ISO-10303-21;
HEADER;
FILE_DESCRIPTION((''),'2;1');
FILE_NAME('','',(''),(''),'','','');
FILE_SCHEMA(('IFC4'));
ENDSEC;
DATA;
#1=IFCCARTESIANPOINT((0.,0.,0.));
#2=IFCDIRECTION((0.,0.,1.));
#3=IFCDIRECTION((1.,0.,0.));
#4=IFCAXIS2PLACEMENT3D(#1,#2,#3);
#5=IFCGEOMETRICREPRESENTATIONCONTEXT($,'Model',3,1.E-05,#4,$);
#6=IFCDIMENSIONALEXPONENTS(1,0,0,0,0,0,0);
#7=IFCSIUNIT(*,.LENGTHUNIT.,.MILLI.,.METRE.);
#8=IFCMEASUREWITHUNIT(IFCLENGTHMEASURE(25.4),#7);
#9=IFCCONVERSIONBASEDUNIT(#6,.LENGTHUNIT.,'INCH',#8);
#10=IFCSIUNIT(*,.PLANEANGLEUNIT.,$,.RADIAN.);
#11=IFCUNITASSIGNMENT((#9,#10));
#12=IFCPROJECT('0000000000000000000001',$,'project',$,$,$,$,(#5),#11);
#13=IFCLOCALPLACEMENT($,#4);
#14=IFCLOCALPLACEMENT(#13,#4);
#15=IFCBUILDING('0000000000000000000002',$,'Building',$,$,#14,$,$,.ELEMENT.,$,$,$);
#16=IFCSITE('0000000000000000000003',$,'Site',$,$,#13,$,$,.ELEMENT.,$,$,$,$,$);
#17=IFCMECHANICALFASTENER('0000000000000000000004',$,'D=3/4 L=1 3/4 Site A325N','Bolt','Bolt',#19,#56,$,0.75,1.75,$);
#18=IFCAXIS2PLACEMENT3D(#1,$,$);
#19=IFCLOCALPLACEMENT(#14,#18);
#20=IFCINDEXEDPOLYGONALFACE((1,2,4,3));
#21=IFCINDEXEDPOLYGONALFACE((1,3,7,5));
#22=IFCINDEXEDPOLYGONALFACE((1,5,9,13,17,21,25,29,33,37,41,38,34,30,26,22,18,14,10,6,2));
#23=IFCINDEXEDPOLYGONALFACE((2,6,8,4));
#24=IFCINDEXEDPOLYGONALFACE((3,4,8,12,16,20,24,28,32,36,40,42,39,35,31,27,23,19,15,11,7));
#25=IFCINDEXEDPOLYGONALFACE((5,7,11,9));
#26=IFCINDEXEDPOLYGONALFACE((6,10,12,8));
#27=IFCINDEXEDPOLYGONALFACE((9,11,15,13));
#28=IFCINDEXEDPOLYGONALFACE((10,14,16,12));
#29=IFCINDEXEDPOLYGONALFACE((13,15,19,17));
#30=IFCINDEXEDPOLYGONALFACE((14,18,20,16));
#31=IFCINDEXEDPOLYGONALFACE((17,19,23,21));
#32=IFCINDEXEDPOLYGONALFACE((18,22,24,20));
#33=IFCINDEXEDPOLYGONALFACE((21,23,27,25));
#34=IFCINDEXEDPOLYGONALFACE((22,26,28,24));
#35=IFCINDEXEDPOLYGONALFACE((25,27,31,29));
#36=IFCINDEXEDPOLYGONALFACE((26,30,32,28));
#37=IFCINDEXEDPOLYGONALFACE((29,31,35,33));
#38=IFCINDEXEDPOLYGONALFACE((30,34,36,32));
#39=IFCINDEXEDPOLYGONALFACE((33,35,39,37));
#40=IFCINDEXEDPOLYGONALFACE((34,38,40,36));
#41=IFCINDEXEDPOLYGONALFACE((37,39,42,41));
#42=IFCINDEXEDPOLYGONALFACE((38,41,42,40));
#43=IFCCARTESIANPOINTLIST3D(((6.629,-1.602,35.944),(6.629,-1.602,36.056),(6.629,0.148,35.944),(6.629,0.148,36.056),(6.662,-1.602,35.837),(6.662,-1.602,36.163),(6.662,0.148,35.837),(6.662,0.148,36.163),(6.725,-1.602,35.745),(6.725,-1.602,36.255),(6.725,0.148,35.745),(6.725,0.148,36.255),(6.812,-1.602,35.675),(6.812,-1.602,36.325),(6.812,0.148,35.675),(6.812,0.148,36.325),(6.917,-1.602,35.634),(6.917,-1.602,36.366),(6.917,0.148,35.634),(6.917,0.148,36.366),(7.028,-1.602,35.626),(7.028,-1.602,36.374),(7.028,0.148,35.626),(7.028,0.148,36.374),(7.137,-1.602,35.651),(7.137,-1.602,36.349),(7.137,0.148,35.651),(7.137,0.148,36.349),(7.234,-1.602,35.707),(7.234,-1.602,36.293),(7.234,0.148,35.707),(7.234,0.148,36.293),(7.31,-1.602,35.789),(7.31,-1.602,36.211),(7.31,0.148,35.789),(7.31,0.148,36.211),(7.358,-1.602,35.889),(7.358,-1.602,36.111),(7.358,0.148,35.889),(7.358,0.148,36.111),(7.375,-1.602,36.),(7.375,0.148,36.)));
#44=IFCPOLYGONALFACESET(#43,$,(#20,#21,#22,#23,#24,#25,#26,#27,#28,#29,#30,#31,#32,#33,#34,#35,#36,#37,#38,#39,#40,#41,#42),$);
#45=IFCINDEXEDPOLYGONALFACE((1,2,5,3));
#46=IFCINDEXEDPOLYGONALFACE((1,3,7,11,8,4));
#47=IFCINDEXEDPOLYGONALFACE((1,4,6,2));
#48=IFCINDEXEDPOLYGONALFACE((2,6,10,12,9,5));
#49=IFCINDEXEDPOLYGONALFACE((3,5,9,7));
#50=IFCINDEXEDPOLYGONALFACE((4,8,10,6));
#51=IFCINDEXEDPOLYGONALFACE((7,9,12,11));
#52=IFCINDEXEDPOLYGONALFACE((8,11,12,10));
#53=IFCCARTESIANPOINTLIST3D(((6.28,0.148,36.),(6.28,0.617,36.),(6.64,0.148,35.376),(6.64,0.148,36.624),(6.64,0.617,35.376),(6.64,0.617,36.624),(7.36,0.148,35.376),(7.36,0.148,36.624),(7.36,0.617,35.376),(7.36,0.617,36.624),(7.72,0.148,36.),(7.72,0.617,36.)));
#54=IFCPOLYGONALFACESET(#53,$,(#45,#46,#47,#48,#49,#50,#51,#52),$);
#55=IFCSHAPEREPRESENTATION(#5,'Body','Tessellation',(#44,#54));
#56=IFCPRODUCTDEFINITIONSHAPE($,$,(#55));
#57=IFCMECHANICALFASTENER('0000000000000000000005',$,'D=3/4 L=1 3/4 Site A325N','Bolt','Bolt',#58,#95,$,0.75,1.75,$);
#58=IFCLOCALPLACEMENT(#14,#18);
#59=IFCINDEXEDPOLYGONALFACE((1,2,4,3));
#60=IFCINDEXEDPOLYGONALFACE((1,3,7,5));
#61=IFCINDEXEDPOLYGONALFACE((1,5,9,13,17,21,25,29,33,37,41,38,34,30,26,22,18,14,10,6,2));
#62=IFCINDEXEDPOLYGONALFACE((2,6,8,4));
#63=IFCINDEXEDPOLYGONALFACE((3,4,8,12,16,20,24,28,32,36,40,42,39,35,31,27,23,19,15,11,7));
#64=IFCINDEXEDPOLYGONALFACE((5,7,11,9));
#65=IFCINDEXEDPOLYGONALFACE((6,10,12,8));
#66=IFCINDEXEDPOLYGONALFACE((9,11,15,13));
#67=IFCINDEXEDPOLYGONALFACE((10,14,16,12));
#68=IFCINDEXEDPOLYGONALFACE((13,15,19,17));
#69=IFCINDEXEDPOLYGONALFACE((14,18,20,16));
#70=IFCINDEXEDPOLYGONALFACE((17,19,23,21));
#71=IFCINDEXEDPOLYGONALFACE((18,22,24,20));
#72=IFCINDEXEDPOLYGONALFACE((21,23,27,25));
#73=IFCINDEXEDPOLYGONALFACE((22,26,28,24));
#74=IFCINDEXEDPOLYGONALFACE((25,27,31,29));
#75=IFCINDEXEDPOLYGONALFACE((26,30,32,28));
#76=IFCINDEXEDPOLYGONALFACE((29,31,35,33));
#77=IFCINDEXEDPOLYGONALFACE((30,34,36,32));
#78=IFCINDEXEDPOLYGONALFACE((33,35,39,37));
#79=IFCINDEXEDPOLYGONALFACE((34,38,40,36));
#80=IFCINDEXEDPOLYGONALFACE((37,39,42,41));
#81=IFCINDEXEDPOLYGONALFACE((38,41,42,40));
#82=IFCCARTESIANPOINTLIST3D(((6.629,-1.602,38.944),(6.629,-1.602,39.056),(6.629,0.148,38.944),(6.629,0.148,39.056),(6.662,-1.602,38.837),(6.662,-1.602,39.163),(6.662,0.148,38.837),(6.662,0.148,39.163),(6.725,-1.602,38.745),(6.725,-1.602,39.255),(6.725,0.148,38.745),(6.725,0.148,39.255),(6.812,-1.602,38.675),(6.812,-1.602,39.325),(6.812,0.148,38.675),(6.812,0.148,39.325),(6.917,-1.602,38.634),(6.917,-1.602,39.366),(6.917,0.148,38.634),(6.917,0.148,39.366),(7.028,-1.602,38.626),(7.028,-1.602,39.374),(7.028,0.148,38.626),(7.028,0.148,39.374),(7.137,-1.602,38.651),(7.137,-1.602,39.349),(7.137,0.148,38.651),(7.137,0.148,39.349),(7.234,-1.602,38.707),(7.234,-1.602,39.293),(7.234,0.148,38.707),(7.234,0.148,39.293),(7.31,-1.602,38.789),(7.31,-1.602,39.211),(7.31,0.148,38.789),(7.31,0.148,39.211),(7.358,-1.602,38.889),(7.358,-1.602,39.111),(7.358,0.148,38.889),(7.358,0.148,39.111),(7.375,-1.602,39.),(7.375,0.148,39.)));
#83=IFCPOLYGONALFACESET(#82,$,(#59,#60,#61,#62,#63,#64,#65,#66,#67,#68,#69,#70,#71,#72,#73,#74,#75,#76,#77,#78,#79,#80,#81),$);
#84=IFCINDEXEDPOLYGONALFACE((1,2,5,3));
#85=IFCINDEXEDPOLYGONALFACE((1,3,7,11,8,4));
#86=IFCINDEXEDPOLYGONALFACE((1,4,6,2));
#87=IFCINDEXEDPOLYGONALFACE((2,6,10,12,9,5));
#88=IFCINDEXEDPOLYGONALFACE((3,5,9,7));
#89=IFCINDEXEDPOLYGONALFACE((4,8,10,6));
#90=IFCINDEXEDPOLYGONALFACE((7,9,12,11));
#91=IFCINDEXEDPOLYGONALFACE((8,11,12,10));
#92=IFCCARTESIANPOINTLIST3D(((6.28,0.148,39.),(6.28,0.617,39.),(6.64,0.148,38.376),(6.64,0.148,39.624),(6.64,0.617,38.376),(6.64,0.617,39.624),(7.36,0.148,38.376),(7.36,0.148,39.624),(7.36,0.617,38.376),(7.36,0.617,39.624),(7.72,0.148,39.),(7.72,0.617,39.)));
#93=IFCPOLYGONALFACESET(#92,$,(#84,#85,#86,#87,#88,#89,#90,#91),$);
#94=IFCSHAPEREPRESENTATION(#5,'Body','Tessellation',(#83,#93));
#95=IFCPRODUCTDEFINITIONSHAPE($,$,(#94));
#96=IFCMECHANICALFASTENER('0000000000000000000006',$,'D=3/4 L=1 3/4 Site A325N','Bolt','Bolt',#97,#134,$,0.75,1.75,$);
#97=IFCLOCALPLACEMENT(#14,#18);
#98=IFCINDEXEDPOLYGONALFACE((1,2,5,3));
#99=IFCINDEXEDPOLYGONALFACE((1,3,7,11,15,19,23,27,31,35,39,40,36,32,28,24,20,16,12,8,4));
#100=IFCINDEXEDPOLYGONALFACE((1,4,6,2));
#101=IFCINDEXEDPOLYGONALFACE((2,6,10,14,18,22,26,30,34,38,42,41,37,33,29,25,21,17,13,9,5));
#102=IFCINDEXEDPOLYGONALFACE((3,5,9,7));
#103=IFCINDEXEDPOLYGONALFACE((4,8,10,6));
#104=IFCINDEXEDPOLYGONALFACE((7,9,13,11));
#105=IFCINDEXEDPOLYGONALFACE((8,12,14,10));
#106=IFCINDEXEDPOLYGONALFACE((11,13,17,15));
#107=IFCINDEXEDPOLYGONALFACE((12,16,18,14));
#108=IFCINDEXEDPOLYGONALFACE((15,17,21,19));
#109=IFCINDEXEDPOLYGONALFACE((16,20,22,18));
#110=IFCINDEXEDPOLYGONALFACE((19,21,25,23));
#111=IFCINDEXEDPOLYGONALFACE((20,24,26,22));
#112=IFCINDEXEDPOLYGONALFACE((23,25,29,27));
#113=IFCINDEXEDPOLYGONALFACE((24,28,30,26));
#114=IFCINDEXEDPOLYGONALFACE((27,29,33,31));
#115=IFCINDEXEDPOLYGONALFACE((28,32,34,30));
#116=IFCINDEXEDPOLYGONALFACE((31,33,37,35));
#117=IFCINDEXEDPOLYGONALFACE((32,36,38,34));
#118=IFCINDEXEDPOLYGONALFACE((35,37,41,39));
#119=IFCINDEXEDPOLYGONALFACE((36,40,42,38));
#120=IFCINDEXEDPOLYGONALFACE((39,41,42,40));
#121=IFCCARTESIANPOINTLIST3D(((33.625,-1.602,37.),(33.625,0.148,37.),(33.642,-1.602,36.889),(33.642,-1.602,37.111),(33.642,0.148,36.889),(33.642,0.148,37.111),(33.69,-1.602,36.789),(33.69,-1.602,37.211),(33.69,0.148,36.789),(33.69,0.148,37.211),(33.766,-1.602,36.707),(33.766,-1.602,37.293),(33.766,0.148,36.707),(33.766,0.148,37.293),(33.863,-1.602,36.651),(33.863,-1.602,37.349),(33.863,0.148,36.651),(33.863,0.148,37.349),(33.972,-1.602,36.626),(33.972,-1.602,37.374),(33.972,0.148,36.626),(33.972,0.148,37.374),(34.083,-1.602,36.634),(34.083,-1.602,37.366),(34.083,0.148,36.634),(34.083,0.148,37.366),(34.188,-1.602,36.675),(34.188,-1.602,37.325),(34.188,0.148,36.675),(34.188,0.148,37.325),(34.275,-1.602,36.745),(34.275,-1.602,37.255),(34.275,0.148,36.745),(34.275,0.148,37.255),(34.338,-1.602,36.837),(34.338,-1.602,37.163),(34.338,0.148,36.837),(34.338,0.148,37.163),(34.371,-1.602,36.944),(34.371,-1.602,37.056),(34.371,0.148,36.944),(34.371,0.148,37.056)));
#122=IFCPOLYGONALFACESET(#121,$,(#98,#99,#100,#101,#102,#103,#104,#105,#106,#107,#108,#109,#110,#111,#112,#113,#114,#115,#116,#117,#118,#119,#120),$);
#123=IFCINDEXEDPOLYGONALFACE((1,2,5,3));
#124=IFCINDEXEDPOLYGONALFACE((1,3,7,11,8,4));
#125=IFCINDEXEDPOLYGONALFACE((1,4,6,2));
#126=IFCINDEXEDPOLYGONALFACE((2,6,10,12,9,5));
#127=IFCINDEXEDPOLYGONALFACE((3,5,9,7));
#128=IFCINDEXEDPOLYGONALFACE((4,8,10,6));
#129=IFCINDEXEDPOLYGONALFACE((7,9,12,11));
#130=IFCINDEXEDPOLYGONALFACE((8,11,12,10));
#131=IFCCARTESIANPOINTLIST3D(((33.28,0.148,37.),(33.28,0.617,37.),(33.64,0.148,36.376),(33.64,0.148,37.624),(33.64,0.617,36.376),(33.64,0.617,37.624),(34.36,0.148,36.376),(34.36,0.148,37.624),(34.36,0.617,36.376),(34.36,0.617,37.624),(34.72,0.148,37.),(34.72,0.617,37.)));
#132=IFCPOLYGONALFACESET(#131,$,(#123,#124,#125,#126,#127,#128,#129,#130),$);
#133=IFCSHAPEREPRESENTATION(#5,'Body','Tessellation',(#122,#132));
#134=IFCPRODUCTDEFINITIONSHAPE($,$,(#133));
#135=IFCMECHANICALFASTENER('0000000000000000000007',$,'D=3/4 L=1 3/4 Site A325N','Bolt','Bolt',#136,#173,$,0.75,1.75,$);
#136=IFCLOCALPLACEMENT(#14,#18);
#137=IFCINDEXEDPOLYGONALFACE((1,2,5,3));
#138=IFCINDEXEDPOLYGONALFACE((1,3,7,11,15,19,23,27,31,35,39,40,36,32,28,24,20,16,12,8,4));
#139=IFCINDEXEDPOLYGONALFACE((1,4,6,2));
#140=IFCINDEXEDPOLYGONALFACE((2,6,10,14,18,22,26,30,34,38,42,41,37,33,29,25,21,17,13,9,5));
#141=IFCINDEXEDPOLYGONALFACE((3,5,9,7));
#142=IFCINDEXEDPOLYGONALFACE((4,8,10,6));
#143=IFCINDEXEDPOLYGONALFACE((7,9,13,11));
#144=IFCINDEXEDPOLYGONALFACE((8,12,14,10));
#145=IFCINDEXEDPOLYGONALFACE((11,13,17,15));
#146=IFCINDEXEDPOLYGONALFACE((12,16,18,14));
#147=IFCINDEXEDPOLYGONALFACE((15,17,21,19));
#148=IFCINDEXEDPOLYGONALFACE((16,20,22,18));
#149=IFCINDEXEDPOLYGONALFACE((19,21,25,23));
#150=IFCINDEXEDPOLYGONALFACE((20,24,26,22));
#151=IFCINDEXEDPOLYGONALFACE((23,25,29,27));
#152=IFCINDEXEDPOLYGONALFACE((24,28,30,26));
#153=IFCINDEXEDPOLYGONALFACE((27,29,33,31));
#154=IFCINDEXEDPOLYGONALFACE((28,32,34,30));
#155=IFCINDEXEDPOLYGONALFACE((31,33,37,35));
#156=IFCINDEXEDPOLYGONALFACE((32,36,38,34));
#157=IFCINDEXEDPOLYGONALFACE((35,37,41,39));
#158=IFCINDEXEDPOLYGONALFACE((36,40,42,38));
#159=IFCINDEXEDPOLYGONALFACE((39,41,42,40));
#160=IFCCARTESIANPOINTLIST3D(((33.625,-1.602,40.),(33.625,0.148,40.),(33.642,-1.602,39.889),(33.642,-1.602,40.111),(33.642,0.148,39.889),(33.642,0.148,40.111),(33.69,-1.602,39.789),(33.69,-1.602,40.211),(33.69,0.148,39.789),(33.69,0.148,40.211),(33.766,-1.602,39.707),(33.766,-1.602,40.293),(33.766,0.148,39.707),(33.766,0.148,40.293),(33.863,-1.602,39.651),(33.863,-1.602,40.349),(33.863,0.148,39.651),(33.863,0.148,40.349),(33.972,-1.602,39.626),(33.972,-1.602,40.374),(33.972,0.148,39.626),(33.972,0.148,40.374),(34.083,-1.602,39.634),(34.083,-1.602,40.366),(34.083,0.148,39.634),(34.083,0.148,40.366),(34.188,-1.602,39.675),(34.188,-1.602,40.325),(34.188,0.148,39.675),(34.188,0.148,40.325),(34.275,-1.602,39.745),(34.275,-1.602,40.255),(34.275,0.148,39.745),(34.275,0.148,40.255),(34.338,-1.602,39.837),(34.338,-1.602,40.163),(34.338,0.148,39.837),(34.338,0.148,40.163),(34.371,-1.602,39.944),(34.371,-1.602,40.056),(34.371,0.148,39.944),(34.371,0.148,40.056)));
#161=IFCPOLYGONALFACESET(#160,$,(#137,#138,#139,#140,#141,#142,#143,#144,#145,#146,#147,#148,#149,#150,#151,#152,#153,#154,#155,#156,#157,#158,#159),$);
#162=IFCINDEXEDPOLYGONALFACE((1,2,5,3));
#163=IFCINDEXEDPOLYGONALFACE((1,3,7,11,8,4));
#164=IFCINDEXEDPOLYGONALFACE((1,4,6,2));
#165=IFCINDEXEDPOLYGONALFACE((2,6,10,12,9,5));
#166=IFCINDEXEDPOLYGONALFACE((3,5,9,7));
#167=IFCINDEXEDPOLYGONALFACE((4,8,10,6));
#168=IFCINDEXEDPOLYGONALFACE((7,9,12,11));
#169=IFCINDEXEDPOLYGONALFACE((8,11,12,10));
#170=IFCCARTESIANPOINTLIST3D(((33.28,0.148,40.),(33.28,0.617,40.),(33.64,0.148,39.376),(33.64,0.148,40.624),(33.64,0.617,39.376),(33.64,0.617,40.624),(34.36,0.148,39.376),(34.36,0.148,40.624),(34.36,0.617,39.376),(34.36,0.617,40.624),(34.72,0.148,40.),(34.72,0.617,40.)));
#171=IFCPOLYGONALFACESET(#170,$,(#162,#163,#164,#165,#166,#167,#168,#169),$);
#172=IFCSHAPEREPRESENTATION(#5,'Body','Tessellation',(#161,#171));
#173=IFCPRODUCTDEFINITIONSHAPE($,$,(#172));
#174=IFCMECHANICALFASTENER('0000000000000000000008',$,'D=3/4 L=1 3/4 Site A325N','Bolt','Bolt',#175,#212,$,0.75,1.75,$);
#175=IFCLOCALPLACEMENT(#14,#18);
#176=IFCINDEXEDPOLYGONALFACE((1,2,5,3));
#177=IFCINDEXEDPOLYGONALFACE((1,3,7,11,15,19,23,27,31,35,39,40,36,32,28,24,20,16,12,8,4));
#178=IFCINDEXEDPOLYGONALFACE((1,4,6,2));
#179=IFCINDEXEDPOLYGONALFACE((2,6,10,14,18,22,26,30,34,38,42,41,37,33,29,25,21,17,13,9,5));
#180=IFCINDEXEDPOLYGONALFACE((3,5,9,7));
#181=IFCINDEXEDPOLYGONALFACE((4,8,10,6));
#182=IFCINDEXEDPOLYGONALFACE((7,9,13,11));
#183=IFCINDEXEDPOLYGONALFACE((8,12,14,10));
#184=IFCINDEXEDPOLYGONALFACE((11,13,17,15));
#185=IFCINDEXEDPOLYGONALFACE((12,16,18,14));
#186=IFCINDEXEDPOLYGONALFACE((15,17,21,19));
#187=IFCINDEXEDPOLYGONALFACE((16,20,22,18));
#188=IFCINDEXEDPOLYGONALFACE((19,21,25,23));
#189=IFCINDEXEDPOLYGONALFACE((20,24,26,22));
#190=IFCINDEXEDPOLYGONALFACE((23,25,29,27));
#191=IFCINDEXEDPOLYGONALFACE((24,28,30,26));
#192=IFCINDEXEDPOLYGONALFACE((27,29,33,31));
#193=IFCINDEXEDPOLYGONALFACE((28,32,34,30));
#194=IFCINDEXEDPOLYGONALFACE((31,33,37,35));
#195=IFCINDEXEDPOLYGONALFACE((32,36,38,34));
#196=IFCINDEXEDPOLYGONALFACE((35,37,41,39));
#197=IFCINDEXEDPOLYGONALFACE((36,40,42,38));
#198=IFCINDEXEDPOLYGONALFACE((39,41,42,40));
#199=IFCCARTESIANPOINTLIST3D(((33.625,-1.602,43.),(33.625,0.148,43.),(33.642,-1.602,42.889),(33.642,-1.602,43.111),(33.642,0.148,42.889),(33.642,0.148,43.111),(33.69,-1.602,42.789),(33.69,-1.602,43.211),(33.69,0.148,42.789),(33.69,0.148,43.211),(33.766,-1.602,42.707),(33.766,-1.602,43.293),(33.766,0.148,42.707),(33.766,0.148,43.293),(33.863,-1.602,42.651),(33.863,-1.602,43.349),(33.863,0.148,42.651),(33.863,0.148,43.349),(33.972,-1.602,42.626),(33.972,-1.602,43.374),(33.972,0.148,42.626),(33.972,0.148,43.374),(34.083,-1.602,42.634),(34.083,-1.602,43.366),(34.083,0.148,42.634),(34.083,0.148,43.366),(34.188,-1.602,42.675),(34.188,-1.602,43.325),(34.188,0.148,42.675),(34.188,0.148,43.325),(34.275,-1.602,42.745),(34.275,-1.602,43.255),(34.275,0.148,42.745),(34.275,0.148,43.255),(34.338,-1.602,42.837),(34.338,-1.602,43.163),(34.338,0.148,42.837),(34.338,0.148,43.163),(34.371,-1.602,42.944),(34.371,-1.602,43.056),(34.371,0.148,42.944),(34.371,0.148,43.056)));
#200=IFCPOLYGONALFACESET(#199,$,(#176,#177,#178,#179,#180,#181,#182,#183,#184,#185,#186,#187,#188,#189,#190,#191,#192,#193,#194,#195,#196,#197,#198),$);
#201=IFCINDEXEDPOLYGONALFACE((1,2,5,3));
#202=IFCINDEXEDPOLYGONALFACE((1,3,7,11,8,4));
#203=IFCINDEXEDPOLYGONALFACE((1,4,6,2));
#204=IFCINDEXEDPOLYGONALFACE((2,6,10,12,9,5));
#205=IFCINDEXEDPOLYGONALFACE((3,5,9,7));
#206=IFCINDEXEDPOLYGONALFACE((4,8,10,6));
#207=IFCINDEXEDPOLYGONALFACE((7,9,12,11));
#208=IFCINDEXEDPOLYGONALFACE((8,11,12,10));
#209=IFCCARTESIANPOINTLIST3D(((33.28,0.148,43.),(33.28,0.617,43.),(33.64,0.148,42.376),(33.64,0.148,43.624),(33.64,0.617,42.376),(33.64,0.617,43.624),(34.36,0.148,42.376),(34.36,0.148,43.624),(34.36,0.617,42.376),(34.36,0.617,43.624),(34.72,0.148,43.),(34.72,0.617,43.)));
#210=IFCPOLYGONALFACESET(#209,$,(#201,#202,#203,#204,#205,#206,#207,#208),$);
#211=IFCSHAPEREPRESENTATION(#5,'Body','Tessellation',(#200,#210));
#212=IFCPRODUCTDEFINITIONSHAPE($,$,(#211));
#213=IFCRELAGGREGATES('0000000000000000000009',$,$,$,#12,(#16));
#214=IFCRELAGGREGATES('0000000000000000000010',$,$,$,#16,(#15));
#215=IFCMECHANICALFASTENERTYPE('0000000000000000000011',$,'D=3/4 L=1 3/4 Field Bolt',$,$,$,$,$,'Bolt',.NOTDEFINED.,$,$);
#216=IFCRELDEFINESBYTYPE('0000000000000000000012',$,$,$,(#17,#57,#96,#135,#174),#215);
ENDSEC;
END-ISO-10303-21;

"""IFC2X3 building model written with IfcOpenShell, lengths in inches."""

from ifc_helpers import new_model, entity, si_unit, converted_unit, frame, origin_with_axes, origin_2d_with_axis, place, context, project, spatial, polyline, circle, outline, extrude, source, transform, mapped, type_object, type_shapes, element, save


model = new_model("IFC2X3")

# Units and contexts
model_context = context("Model", 3, precision=1e-05, world=origin_with_axes())
ifc_project = project(units=[converted_unit("LENGTHUNIT", "INCH", entity("IfcLengthMeasure", 25.4), si_unit("LENGTHUNIT", "METRE", prefix="MILLI"), dimensions=[1, 0, 0, 0, 0, 0, 0]), si_unit("PLANEANGLEUNIT", "RADIAN")], contexts=[model_context])

# Site, building
site_placement = place(None, origin_with_axes())
site = spatial("IfcSite", under=ifc_project, at=site_placement, Name="Site", CompositionType="ELEMENT")
building_placement = place(site_placement, origin_with_axes())
building = spatial("IfcBuilding", under=site, at=building_placement, Name="Building", CompositionType="ELEMENT")

# Mechanical fasteners
mechanical_fastener_type_1 = type_object("IfcMechanicalFastenerType", Name="D=3/4 L=1 3/4 Field Bolt", ElementType="Bolt")
shared_shape_1 = source(origin_with_axes(), model_context, "Body", "SweptSolid", [
    extrude(circle(Radius=0.375, at=origin_2d_with_axis()), frame((0.0, 0.0, 0.0), z_axis=(1.0, 0.0, 0.0), x_axis=(0.0, 1.0, 0.0)), (0.0, 0.0, 1.0), 1.75),
    extrude(outline(polyline([(-0.72, 0.0), (-0.36, 0.624), (0.36, 0.624), (0.72, 0.0), (0.36, -0.624), (-0.36, -0.624), (-0.72, 0.0)])), frame((0.0, 0.0, 0.0), z_axis=(1.0, 0.0, 0.0), x_axis=(0.0, 1.0, 0.0)), (0.0, 0.0, -1.0), 0.47),
])
type_shapes(mechanical_fastener_type_1, [shared_shape_1])
placement_1 = place(building_placement, frame((0.0, 0.0, 46.0), z_axis=(0.0, 0.0, 1.0), x_axis=(1.0, 0.0, 0.0)))
placement_2 = place(placement_1, frame((7.0, 0.148, -4.0), z_axis=(0.0, 0.0, 1.0), x_axis=(0.0, -1.0, 0.0)))
for number, where, z_axis, x_axis, name in (
    (1, (0.0, 0.0, -6.0), (0.0, 0.0, 1.0), (1.0, 0.0, 0.0), "D=3/4 L=1 3/4 Site A325N"),
    (2, (0.0, 0.0, -3.0), (0.0, 0.0, 1.0), (1.0, 0.0, 0.0), "D=3/4 L=1 3/4 Site A325N"),
):
    element("IfcMechanicalFastener", number, at=place(placement_2, frame(where, z_axis=z_axis, x_axis=x_axis)), type_object=mechanical_fastener_type_1, Name=name, Description="Bolt", ObjectType="Bolt", NominalDiameter=0.75, NominalLength=1.75, context=model_context, shape_type="MappedRepresentation", body=[
        mapped(shared_shape_1, transform((0.0, 0.0, 0.0), scale=1.0)),
    ])
placement_3 = place(building_placement, frame((36.0, 0.0, 46.0), z_axis=(0.0, 0.0, 1.0), x_axis=(0.0, -1.0, 0.0)))
placement_4 = place(placement_3, frame((-0.148, -2.0, -3.0), z_axis=(0.0, 0.0, -1.0), x_axis=(1.0, 0.0, 0.0)))
for number, where, z_axis, x_axis, name in (
    (3, (0.0, 0.0, 6.0), (0.0, 0.0, 1.0), (1.0, 0.0, 0.0), "D=3/4 L=1 3/4 Site A325N"),
    (4, (0.0, 0.0, 3.0), (0.0, 0.0, 1.0), (1.0, 0.0, 0.0), "D=3/4 L=1 3/4 Site A325N"),
    (5, (0.0, 0.0, 0.0), (0.0, 0.0, 1.0), (1.0, 0.0, 0.0), "D=3/4 L=1 3/4 Site A325N"),
):
    element("IfcMechanicalFastener", number, at=place(placement_4, frame(where, z_axis=z_axis, x_axis=x_axis)), type_object=mechanical_fastener_type_1, Name=name, Description="Bolt", ObjectType="Bolt", NominalDiameter=0.75, NominalLength=1.75, context=model_context, shape_type="MappedRepresentation", body=[
        mapped(shared_shape_1, transform((0.0, 0.0, 0.0), scale=1.0)),
    ])

save(model, "model.ifc")
